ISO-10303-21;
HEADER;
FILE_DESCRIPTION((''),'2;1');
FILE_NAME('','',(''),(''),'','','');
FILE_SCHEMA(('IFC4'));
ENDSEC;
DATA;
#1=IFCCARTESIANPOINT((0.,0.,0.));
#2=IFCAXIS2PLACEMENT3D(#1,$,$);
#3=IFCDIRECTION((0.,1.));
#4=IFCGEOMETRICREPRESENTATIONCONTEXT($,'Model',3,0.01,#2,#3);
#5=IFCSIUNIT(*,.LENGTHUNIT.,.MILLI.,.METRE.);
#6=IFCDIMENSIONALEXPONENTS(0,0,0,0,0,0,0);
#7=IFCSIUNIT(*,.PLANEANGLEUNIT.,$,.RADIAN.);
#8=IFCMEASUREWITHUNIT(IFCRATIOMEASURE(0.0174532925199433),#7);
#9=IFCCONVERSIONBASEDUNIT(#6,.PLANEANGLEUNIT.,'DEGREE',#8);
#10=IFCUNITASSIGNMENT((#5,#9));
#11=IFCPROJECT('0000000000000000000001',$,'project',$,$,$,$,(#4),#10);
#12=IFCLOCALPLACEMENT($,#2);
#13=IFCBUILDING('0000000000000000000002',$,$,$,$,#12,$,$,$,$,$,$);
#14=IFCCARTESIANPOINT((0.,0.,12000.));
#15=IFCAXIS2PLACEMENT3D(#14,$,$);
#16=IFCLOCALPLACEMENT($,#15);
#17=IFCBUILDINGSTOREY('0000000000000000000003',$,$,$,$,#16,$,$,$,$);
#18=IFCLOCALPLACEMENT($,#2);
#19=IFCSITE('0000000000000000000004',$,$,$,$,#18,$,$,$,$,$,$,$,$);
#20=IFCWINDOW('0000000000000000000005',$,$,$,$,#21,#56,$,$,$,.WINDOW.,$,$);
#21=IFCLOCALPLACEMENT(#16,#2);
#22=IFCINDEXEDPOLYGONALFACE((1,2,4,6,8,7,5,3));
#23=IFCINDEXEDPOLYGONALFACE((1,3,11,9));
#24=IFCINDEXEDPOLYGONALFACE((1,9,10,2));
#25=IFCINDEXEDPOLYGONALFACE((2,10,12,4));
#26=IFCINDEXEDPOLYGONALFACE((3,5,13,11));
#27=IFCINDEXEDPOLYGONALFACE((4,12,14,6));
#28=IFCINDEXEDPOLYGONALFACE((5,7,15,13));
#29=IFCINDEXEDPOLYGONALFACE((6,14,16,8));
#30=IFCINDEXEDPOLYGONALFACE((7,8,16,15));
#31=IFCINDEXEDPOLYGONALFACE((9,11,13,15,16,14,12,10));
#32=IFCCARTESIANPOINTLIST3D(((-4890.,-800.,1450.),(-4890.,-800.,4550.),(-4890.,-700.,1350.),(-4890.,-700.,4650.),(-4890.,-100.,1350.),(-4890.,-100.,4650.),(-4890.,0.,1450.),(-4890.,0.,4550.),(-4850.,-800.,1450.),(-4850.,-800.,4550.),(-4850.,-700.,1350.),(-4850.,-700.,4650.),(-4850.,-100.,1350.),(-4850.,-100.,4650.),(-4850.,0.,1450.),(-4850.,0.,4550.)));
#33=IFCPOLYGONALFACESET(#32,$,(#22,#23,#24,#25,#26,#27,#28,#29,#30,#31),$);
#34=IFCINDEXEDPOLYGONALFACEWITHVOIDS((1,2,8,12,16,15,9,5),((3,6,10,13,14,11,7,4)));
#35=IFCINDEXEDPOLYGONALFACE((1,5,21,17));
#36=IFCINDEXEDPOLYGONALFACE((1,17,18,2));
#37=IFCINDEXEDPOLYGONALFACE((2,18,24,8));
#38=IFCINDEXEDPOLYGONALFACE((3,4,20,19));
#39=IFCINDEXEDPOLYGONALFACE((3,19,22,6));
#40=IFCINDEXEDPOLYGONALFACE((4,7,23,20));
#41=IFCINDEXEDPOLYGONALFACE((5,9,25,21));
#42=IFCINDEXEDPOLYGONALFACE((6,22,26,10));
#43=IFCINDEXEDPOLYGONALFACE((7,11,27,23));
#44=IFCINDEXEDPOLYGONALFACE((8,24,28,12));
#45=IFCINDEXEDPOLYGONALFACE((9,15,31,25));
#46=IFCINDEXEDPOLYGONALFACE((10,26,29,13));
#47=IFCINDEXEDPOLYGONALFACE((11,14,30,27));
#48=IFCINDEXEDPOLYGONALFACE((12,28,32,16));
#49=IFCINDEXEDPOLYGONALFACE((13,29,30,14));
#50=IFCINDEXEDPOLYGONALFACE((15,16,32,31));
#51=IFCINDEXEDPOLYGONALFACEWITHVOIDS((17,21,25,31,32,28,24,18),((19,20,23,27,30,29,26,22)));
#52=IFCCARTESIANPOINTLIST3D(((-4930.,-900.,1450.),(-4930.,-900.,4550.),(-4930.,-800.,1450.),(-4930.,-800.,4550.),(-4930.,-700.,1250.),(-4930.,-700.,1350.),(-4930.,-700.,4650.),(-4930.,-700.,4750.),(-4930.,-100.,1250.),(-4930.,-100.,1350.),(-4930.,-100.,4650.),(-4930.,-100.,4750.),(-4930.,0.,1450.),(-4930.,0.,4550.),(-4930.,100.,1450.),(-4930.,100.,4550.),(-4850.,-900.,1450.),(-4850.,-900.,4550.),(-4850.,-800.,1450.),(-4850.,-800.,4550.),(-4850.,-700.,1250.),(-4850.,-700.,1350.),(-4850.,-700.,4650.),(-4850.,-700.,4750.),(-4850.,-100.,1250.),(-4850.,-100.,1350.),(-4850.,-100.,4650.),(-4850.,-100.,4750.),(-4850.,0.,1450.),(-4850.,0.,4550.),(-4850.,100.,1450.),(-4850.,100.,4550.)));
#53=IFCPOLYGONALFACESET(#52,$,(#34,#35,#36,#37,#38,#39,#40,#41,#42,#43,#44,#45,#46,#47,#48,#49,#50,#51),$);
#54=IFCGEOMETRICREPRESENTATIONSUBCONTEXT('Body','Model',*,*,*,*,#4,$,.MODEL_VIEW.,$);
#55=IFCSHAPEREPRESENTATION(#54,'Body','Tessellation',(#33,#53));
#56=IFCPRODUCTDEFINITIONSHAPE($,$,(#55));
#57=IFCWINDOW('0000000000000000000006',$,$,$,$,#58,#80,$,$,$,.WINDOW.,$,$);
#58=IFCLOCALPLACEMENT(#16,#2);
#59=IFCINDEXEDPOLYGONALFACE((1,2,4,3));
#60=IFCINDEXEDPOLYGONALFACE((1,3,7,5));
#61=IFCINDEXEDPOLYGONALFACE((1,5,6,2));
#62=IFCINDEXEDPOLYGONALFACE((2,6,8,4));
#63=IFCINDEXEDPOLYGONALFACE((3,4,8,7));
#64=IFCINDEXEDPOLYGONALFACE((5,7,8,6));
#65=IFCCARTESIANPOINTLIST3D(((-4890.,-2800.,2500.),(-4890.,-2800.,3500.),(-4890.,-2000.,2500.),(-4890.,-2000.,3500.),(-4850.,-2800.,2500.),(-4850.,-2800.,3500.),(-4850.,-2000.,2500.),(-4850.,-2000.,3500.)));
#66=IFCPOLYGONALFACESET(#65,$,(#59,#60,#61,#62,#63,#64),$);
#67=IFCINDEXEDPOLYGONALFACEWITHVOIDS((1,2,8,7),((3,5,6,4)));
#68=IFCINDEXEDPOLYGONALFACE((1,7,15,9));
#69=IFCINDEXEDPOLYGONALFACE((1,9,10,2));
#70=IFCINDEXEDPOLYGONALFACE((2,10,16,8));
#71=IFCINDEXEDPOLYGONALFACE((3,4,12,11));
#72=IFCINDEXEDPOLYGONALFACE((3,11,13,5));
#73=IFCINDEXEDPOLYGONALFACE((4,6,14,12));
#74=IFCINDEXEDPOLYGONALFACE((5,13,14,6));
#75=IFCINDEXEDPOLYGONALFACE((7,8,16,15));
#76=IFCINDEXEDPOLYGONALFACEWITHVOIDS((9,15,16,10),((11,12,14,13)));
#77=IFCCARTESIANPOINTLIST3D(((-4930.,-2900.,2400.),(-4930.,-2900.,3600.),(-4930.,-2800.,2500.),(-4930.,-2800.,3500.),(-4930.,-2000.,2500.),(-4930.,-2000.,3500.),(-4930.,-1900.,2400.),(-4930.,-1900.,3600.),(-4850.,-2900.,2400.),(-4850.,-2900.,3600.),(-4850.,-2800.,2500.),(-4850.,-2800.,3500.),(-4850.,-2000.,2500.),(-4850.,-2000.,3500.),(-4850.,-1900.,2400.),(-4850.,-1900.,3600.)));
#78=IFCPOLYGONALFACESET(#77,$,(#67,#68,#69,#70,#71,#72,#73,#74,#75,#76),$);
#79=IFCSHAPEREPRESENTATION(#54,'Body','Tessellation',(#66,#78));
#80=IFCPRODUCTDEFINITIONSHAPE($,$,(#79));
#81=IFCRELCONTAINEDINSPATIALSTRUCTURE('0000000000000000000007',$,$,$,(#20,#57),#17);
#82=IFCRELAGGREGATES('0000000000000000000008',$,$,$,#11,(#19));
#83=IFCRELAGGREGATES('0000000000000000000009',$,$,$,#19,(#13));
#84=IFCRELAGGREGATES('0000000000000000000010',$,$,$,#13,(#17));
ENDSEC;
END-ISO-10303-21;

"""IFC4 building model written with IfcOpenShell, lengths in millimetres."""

from ifc_helpers import new_model, entity, si_unit, converted_unit, direction, frame, origin, place, context, subcontext, project, spatial, element, save


model = new_model("IFC4")

# Units and contexts
model_context = context("Model", 3, precision=0.01, world=origin(), true_north=direction((0.0, 1.0)))
body_context = subcontext(model_context, "Body", "Model", "MODEL_VIEW")
ifc_project = project(units=[si_unit("LENGTHUNIT", "METRE", prefix="MILLI"), converted_unit("PLANEANGLEUNIT", "DEGREE", entity("IfcRatioMeasure", 0.0174532925199433), si_unit("PLANEANGLEUNIT", "RADIAN"), dimensions=[0, 0, 0, 0, 0, 0, 0])], contexts=[model_context])

# Site, building, storey
site_placement = place(None, origin())
site = spatial("IfcSite", under=ifc_project, at=site_placement)
building_placement = place(None, origin())
building = spatial("IfcBuilding", under=site, at=building_placement)
storey_placement = place(None, frame((0.0, 0.0, 12000.0)))
storey = spatial("IfcBuildingStorey", under=building, at=storey_placement)

# Shared definitions
cartesian_point_1 = entity("IfcCartesianPoint", [-400.0, -1550.0])
shared_polyline_1 = entity("IfcPolyline", [cartesian_point_1, entity("IfcCartesianPoint", [-400.0, 1550.0]), entity("IfcCartesianPoint", [-300.0, 1650.0]), entity("IfcCartesianPoint", [300.0, 1650.0]), entity("IfcCartesianPoint", [400.0, 1550.0]), entity("IfcCartesianPoint", [400.0, -1550.0]), entity("IfcCartesianPoint", [300.0, -1650.0]), entity("IfcCartesianPoint", [-300.0, -1650.0]), cartesian_point_1])
cartesian_point_2 = entity("IfcCartesianPoint", [-400.0, -500.0])
shared_polyline_2 = entity("IfcPolyline", [cartesian_point_2, entity("IfcCartesianPoint", [-400.0, 500.0]), entity("IfcCartesianPoint", [-400.0, 500.0]), entity("IfcCartesianPoint", [400.0, 500.0]), entity("IfcCartesianPoint", [400.0, 500.0]), entity("IfcCartesianPoint", [400.0, -500.0]), entity("IfcCartesianPoint", [400.0, -500.0]), entity("IfcCartesianPoint", [-400.0, -500.0]), cartesian_point_2])

# Shared definitions
wall_1_placement = place(storey_placement, frame((-4900.0, 100.0, 0.0), z_axis=(0.0, 0.0, 1.0), x_axis=(0.0, -1.0, 0.0)))
window_1_placement = place(wall_1_placement, frame((500.0, 50.0, 3000.0)))
window_2_placement = place(wall_1_placement, frame((2500.0, 50.0, 3000.0)))

# Windows
cartesian_point_3 = entity("IfcCartesianPoint", [-500.0, -1550.0])
element("IfcWindow", 1, at=window_1_placement, inside=storey, PredefinedType="WINDOW", context=body_context, shape_type="SweptSolid", body=[
    entity("IfcExtrudedAreaSolid", entity("IfcArbitraryClosedProfileDef", "AREA", None, shared_polyline_1), entity("IfcAxis2Placement3D", entity("IfcCartesianPoint", [0.0, 0.0, 0.0]), entity("IfcDirection", [0.0, -1.0, 0.0]), entity("IfcDirection", [1.0, 0.0, 0.0])), entity("IfcDirection", [0.0, 0.0, 1.0]), 40.0),
    entity("IfcExtrudedAreaSolid", entity("IfcArbitraryProfileDefWithVoids", "AREA", None, entity("IfcPolyline", [cartesian_point_3, entity("IfcCartesianPoint", [-500.0, 1550.0]), entity("IfcCartesianPoint", [-300.0, 1750.0]), entity("IfcCartesianPoint", [300.0, 1750.0]), entity("IfcCartesianPoint", [500.0, 1550.0]), entity("IfcCartesianPoint", [500.0, -1550.0]), entity("IfcCartesianPoint", [300.0, -1750.0]), entity("IfcCartesianPoint", [-300.0, -1750.0]), cartesian_point_3]), [shared_polyline_1]), entity("IfcAxis2Placement3D", entity("IfcCartesianPoint", [0.0, 0.0, 0.0]), entity("IfcDirection", [0.0, -1.0, 0.0]), entity("IfcDirection", [1.0, 0.0, 0.0])), entity("IfcDirection", [0.0, 0.0, 1.0]), 80.0),
])
cartesian_point_4 = entity("IfcCartesianPoint", [-500.0, -600.0])
element("IfcWindow", 2, at=window_2_placement, inside=storey, PredefinedType="WINDOW", context=body_context, shape_type="SweptSolid", body=[
    entity("IfcExtrudedAreaSolid", entity("IfcArbitraryClosedProfileDef", "AREA", None, shared_polyline_2), entity("IfcAxis2Placement3D", entity("IfcCartesianPoint", [0.0, 0.0, 0.0]), entity("IfcDirection", [0.0, -1.0, 0.0]), entity("IfcDirection", [1.0, 0.0, 0.0])), entity("IfcDirection", [0.0, 0.0, 1.0]), 40.0),
    entity("IfcExtrudedAreaSolid", entity("IfcArbitraryProfileDefWithVoids", "AREA", None, entity("IfcPolyline", [cartesian_point_4, entity("IfcCartesianPoint", [-500.0, 600.0]), entity("IfcCartesianPoint", [-500.0, 600.0]), entity("IfcCartesianPoint", [500.0, 600.0]), entity("IfcCartesianPoint", [500.0, 600.0]), entity("IfcCartesianPoint", [500.0, -600.0]), entity("IfcCartesianPoint", [500.0, -600.0]), entity("IfcCartesianPoint", [-500.0, -600.0]), cartesian_point_4]), [shared_polyline_2]), entity("IfcAxis2Placement3D", entity("IfcCartesianPoint", [0.0, 0.0, 0.0]), entity("IfcDirection", [0.0, -1.0, 0.0]), entity("IfcDirection", [1.0, 0.0, 0.0])), entity("IfcDirection", [0.0, 0.0, 1.0]), 80.0),
])

save(model, "model.ifc")
